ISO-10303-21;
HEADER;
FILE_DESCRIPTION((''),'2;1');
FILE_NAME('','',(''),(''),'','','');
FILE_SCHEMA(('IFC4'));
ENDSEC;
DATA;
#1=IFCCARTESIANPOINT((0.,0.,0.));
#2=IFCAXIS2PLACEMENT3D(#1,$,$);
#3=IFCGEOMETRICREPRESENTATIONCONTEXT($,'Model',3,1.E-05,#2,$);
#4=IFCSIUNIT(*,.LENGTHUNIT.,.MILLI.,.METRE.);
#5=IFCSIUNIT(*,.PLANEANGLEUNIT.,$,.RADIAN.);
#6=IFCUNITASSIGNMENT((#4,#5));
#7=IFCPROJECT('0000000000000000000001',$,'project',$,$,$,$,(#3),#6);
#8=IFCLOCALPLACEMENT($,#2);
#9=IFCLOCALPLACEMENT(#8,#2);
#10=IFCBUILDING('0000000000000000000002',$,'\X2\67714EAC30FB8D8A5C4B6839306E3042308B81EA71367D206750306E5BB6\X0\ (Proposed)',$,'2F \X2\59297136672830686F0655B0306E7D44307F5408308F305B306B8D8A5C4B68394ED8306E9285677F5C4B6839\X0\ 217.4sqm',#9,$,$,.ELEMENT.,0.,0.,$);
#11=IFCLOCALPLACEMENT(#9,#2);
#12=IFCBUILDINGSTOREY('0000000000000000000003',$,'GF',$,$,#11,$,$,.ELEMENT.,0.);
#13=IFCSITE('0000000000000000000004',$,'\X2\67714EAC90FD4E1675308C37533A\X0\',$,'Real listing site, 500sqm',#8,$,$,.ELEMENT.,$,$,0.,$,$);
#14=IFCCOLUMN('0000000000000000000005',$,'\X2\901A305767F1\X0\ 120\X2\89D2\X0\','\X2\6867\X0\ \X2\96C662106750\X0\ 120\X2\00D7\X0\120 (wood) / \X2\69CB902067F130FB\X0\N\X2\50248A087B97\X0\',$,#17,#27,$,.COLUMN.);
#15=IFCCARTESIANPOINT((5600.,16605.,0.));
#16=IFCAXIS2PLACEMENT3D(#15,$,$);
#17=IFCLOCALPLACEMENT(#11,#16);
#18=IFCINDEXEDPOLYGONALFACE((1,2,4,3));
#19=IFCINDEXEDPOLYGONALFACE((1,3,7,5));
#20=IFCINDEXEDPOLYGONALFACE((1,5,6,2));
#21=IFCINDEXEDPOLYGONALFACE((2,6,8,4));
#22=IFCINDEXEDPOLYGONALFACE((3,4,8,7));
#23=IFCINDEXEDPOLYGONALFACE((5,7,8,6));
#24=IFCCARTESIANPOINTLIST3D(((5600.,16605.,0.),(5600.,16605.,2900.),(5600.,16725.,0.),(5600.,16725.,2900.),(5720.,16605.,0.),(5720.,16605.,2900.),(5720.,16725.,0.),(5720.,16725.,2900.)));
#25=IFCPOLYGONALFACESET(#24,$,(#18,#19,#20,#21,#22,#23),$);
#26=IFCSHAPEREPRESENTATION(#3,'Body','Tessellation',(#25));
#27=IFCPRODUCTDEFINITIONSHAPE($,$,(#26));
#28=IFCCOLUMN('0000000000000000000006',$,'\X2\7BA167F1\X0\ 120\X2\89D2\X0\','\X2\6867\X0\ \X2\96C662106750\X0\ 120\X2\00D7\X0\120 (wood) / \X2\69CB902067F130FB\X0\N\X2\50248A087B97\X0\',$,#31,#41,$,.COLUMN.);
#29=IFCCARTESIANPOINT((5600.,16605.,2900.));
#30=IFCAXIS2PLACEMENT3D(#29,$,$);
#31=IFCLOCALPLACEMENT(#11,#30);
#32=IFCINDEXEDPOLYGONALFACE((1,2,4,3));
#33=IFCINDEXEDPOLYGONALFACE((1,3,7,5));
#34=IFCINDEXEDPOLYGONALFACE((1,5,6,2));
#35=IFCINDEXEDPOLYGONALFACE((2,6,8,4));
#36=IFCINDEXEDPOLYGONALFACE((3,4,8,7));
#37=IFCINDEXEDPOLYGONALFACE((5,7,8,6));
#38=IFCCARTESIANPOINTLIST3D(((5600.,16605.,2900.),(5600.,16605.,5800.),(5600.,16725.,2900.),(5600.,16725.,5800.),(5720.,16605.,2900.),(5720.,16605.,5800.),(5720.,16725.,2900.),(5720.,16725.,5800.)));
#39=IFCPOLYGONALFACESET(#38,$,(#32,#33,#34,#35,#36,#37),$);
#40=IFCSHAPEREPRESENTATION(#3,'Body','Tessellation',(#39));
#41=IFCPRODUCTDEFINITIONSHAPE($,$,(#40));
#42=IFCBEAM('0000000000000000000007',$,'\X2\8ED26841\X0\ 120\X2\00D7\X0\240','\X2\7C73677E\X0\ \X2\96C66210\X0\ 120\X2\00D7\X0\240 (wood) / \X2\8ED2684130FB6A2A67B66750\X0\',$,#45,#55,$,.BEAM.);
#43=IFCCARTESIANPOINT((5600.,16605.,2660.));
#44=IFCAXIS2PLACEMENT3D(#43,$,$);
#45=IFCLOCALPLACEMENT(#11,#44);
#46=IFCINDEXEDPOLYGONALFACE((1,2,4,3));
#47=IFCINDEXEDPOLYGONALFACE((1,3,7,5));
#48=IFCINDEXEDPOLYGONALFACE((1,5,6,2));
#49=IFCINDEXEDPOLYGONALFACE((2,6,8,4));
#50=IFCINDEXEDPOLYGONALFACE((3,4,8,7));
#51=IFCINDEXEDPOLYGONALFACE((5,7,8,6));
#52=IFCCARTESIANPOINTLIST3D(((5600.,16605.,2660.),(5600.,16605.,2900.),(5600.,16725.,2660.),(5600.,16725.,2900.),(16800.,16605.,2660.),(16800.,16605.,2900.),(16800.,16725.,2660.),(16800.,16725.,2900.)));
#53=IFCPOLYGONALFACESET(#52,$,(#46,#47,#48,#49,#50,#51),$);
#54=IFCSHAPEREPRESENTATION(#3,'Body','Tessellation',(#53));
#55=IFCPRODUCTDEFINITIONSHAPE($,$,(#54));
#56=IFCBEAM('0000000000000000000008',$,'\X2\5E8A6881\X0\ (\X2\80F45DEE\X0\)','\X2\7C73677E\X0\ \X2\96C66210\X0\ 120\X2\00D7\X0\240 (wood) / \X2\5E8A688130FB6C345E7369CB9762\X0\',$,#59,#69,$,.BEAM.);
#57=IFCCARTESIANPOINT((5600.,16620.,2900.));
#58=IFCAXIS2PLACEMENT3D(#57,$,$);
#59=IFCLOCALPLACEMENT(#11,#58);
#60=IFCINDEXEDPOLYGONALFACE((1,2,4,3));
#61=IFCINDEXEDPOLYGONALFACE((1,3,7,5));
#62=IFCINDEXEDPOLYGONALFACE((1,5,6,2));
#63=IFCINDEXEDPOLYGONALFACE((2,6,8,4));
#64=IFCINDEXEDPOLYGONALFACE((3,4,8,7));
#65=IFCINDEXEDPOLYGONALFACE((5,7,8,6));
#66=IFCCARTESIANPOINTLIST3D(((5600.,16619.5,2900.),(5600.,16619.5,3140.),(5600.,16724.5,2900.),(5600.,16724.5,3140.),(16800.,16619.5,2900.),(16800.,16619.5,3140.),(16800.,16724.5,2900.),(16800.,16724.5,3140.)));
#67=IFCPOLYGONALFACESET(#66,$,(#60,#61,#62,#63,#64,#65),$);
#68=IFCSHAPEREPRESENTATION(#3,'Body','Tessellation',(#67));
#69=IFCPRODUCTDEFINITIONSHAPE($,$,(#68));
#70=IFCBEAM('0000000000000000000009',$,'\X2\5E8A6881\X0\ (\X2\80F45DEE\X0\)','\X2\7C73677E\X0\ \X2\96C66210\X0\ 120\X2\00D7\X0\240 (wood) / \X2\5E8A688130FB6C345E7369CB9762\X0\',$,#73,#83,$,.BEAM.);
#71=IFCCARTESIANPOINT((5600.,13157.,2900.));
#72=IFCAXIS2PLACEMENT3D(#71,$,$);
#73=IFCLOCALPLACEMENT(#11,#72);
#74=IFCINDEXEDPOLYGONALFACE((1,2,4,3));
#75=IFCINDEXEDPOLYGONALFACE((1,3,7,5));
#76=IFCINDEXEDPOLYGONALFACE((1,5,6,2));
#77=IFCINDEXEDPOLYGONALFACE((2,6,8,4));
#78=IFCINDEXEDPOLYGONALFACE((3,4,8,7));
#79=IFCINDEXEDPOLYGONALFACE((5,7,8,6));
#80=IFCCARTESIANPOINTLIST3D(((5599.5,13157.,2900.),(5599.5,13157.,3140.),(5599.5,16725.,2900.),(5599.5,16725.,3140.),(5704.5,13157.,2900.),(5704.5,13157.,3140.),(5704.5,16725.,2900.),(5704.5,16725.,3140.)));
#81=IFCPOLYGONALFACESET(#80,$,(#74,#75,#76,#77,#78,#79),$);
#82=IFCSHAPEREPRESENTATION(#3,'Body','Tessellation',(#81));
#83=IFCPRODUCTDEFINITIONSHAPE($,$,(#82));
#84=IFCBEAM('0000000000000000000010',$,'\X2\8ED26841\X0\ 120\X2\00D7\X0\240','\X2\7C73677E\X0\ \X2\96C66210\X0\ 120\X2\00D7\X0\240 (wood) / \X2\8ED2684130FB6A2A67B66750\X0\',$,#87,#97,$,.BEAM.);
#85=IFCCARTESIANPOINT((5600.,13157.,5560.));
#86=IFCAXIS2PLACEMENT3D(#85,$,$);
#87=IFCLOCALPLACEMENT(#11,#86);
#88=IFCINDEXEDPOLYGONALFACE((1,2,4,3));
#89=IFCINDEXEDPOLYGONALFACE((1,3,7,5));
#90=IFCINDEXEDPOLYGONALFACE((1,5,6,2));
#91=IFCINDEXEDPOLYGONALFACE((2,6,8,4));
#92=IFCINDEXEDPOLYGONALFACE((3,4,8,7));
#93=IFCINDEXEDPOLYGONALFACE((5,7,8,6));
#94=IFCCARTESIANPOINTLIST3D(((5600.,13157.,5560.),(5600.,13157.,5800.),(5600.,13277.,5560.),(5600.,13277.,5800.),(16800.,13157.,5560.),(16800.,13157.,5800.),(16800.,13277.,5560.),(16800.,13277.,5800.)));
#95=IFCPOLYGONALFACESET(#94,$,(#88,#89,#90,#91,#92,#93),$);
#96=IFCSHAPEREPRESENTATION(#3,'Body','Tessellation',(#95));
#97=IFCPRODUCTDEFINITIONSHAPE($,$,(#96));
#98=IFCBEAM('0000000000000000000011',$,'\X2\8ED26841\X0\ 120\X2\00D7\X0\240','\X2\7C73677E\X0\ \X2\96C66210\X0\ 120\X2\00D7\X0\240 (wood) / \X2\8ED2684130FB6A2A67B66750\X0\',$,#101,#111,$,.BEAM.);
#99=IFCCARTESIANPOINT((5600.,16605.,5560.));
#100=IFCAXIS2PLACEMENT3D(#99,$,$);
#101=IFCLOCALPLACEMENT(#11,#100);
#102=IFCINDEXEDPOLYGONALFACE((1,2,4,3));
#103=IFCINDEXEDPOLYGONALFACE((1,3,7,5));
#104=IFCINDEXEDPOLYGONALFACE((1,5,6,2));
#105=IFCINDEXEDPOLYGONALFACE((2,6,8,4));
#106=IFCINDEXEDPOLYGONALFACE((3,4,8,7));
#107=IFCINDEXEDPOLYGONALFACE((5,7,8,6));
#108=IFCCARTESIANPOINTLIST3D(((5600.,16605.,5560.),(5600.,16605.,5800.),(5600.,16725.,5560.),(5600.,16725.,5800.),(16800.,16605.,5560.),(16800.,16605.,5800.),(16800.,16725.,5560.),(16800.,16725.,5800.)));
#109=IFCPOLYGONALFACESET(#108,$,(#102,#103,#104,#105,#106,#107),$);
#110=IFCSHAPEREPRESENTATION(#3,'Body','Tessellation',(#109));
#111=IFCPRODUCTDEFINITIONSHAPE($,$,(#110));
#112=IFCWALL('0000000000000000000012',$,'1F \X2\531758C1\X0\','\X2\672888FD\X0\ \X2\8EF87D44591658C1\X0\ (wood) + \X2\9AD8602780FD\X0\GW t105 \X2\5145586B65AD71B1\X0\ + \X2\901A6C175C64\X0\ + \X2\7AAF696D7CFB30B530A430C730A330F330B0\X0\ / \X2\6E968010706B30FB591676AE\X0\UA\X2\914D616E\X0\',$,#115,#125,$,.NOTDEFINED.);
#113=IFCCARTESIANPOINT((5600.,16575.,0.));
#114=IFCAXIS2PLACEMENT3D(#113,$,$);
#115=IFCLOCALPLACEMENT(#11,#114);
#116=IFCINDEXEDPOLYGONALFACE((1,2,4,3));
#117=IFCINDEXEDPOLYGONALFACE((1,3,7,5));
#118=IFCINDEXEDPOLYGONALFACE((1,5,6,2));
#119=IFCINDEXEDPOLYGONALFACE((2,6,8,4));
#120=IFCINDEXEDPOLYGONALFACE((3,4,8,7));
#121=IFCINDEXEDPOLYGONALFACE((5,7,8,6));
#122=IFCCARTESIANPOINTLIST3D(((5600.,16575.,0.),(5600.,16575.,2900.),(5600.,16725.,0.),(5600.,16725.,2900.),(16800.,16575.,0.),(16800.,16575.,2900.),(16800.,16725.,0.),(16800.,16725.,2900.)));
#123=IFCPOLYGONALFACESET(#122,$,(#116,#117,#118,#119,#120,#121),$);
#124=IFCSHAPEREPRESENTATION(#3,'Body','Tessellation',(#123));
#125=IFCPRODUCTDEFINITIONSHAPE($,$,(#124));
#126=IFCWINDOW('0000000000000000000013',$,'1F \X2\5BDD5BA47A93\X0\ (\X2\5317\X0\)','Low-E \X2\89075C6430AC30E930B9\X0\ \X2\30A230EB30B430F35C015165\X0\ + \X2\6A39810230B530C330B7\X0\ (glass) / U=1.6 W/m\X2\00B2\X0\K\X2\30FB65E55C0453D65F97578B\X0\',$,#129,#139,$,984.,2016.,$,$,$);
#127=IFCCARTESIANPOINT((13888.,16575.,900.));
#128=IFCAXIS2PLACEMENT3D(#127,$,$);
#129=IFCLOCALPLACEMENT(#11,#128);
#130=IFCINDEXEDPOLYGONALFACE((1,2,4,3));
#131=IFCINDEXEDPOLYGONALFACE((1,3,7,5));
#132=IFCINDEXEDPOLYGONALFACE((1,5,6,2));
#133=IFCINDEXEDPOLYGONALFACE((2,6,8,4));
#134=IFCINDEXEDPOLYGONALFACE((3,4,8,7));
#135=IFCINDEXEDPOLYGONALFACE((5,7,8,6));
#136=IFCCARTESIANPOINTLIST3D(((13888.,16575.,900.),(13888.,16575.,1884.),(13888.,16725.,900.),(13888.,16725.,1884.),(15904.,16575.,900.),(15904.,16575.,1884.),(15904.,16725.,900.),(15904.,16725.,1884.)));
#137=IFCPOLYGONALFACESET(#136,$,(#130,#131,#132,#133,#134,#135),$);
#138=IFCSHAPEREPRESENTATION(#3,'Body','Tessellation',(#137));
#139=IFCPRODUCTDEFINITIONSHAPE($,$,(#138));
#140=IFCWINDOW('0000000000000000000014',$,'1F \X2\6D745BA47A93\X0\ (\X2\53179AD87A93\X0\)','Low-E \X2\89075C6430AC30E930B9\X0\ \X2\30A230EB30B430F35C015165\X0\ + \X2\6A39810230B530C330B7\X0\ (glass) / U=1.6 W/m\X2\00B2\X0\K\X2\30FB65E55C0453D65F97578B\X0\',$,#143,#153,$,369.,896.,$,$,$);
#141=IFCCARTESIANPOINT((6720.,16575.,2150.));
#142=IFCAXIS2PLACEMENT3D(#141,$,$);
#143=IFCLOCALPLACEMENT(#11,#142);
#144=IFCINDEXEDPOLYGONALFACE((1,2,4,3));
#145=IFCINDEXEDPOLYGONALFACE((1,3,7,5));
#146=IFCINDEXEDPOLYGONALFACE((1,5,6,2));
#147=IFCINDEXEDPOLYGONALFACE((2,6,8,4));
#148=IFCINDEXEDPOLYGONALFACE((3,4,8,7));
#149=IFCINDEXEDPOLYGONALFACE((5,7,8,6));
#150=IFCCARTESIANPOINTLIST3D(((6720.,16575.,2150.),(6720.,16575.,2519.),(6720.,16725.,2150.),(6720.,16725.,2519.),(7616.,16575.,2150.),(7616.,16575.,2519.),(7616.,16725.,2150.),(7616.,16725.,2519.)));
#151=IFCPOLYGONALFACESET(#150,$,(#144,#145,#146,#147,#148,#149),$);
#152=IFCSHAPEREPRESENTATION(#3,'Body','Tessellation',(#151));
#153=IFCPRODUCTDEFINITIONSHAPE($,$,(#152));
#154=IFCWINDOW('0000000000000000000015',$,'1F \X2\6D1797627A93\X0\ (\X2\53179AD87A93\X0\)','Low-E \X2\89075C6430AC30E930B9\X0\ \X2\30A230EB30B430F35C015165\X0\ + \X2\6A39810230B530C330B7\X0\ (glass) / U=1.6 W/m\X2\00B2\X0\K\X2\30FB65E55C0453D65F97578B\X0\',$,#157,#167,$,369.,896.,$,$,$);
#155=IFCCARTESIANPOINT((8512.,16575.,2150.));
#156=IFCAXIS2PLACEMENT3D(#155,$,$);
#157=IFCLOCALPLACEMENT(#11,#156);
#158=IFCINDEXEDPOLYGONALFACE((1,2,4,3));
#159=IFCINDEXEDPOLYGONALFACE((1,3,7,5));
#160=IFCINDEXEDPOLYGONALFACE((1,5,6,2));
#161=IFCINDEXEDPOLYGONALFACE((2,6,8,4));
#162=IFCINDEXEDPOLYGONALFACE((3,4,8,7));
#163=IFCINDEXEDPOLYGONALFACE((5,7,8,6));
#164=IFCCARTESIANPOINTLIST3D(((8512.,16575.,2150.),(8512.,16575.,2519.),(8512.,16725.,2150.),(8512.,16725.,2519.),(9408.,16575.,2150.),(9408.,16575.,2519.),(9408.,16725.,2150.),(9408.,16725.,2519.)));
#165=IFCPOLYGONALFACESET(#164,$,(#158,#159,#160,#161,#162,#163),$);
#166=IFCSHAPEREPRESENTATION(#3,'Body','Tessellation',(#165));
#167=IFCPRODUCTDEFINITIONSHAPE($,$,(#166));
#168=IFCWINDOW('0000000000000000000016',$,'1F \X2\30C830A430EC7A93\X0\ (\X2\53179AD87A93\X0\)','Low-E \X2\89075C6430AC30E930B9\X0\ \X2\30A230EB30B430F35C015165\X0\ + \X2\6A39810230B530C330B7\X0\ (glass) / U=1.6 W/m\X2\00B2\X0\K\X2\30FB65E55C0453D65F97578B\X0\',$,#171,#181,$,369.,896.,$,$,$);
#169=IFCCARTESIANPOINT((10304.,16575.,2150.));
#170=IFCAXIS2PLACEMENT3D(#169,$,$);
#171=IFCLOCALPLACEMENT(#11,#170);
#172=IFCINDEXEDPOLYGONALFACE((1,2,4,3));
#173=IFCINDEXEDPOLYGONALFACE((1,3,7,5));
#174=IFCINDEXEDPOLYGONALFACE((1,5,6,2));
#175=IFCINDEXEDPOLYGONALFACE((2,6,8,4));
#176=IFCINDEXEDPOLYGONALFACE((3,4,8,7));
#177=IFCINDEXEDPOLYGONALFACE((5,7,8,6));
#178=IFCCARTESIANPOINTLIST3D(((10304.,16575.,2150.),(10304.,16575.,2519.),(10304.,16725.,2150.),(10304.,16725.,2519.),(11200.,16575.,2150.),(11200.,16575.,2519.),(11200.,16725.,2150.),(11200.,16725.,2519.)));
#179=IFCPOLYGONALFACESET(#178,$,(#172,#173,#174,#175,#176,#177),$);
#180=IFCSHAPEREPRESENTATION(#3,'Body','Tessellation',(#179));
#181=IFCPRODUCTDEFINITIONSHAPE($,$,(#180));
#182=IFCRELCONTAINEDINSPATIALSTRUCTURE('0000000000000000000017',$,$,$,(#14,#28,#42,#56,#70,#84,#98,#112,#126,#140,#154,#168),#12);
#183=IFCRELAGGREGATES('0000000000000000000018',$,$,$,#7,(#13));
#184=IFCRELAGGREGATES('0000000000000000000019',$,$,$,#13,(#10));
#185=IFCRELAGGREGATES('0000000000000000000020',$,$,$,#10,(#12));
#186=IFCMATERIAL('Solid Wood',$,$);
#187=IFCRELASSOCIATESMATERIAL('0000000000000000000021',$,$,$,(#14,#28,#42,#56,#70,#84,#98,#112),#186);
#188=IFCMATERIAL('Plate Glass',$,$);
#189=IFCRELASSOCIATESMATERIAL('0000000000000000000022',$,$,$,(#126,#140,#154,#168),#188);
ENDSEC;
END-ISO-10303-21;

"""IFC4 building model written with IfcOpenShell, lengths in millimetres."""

from ifc_helpers import new_model, si_unit, frame, frame_2d, origin, place, context, project, spatial, rectangle, extrude, material, element, fill, save


model = new_model("IFC4")

# Units and contexts
model_context = context("Model", 3, precision=1e-05, world=origin())
ifc_project = project(units=[si_unit("LENGTHUNIT", "METRE", prefix="MILLI"), si_unit("PLANEANGLEUNIT", "RADIAN")], contexts=[model_context])

# Site, building, storey
site_placement = place(None, origin())
site = spatial("IfcSite", under=ifc_project, at=site_placement, Name="東京都世田谷区", ObjectType="Real listing site, 500sqm", CompositionType="ELEMENT", RefElevation=0.0)
building_placement = place(site_placement, origin())
building = spatial("IfcBuilding", under=site, at=building_placement, Name="東京・越屋根のある自然素材の家 (Proposed)", ObjectType="2F 天然木と漆喰の組み合わせに越屋根付の銅板屋根 217.4sqm", CompositionType="ELEMENT", ElevationOfRefHeight=0.0, ElevationOfTerrain=0.0)
storey_placement = place(building_placement, origin())
storey = spatial("IfcBuildingStorey", under=building, at=storey_placement, Name="GF", CompositionType="ELEMENT", Elevation=0.0)

# Columns
ifc_material_1 = material(Name="Solid Wood")
column_1_placement = place(storey_placement, frame((5600.0, 16605.0, 0.0)))
element("IfcColumn", 1, at=column_1_placement, inside=storey, material=ifc_material_1, Name="通し柱 120角", Description="桧 集成材 120×120 (wood) / 構造柱・N値計算", PredefinedType="COLUMN", context=model_context, shape_type="SweptSolid", body=[
    extrude(rectangle(XDim=120.0, YDim=120.0, at=frame_2d((60.0, 60.0))), frame((5600.0, 16605.0, 0.0)), (0.0, 0.0, 1.0), 2900.0),
])
column_2_placement = place(storey_placement, frame((5600.0, 16605.0, 2900.0)))
element("IfcColumn", 2, at=column_2_placement, inside=storey, material=ifc_material_1, Name="管柱 120角", Description="桧 集成材 120×120 (wood) / 構造柱・N値計算", PredefinedType="COLUMN", context=model_context, shape_type="SweptSolid", body=[
    extrude(rectangle(XDim=120.0, YDim=120.0, at=frame_2d((60.0, 60.0))), frame((5600.0, 16605.0, 2900.0)), (0.0, 0.0, 1.0), 2900.0),
])

# Beams
beam_1_placement = place(storey_placement, frame((5600.0, 16605.0, 2660.0)))
element("IfcBeam", 3, at=beam_1_placement, inside=storey, material=ifc_material_1, Name="軒桁 120×240", Description="米松 集成 120×240 (wood) / 軒桁・横架材", PredefinedType="BEAM", context=model_context, shape_type="SweptSolid", body=[
    extrude(rectangle(XDim=11200.0, YDim=120.0, at=frame_2d((5600.0, 60.0))), frame((5600.0, 16605.0, 2660.0)), (0.0, 0.0, 1.0), 240.0),
])
beam_2_placement = place(storey_placement, frame((5600.0, 16620.0, 2900.0)))
element("IfcBeam", 4, at=beam_2_placement, inside=storey, material=ifc_material_1, Name="床梁 (胴差)", Description="米松 集成 120×240 (wood) / 床梁・水平構面", PredefinedType="BEAM", context=model_context, shape_type="SweptSolid", body=[
    extrude(rectangle(XDim=11200.0, YDim=105.0, at=frame_2d((5600.0, 52.0))), frame((5600.0, 16620.0, 2900.0)), (0.0, 0.0, 1.0), 240.0),
])
beam_3_placement = place(storey_placement, frame((5600.0, 13157.0, 2900.0)))
element("IfcBeam", 5, at=beam_3_placement, inside=storey, material=ifc_material_1, Name="床梁 (胴差)", Description="米松 集成 120×240 (wood) / 床梁・水平構面", PredefinedType="BEAM", context=model_context, shape_type="SweptSolid", body=[
    extrude(rectangle(XDim=105.0, YDim=3568.0, at=frame_2d((52.0, 1784.0))), frame((5600.0, 13157.0, 2900.0)), (0.0, 0.0, 1.0), 240.0),
])
beam_4_placement = place(storey_placement, frame((5600.0, 13157.0, 5560.0)))
element("IfcBeam", 6, at=beam_4_placement, inside=storey, material=ifc_material_1, Name="軒桁 120×240", Description="米松 集成 120×240 (wood) / 軒桁・横架材", PredefinedType="BEAM", context=model_context, shape_type="SweptSolid", body=[
    extrude(rectangle(XDim=11200.0, YDim=120.0, at=frame_2d((5600.0, 60.0))), frame((5600.0, 13157.0, 5560.0)), (0.0, 0.0, 1.0), 240.0),
])
beam_5_placement = place(storey_placement, frame((5600.0, 16605.0, 5560.0)))
element("IfcBeam", 7, at=beam_5_placement, inside=storey, material=ifc_material_1, Name="軒桁 120×240", Description="米松 集成 120×240 (wood) / 軒桁・横架材", PredefinedType="BEAM", context=model_context, shape_type="SweptSolid", body=[
    extrude(rectangle(XDim=11200.0, YDim=120.0, at=frame_2d((5600.0, 60.0))), frame((5600.0, 16605.0, 5560.0)), (0.0, 0.0, 1.0), 240.0),
])

# Wall, openings, windows
wall_1_placement = place(storey_placement, frame((5600.0, 16575.0, 0.0)))
wall_1 = element("IfcWall", 8, at=wall_1_placement, inside=storey, material=ifc_material_1, Name="1F 北壁", Description="木製 軸組外壁 (wood) + 高性能GW t105 充填断熱 + 通気層 + 窯業系サイディング / 準耐火・外皮UA配慮", PredefinedType="NOTDEFINED", context=model_context, shape_type="SweptSolid", body=[
    extrude(rectangle(XDim=11200.0, YDim=150.0, at=frame_2d((5600.0, 75.0))), frame((5600.0, 16575.0, 0.0)), (0.0, 0.0, 1.0), 2900.0),
])
opening_1_placement = place(storey_placement, frame((13888.0, 16575.0, 900.0)))
opening_1 = element("IfcOpeningElement", 9, at=opening_1_placement, cuts=wall_1, PredefinedType="NOTDEFINED", context=model_context, shape_type="SweptSolid", body=[
    extrude(rectangle(XDim=2016.0, YDim=150.0, at=frame_2d((1008.0, 75.0))), frame((13888.0, 16575.0, 900.0)), (0.0, 0.0, 1.0), 984.0),
])
opening_2_placement = place(storey_placement, frame((6720.0, 16575.0, 2150.0)))
opening_2 = element("IfcOpeningElement", 10, at=opening_2_placement, cuts=wall_1, PredefinedType="NOTDEFINED", context=model_context, shape_type="SweptSolid", body=[
    extrude(rectangle(XDim=896.0, YDim=150.0, at=frame_2d((448.0, 75.0))), frame((6720.0, 16575.0, 2150.0)), (0.0, 0.0, 1.0), 369.0),
])
opening_3_placement = place(storey_placement, frame((8512.0, 16575.0, 2150.0)))
opening_3 = element("IfcOpeningElement", 11, at=opening_3_placement, cuts=wall_1, PredefinedType="NOTDEFINED", context=model_context, shape_type="SweptSolid", body=[
    extrude(rectangle(XDim=896.0, YDim=150.0, at=frame_2d((448.0, 75.0))), frame((8512.0, 16575.0, 2150.0)), (0.0, 0.0, 1.0), 369.0),
])
opening_4_placement = place(storey_placement, frame((10304.0, 16575.0, 2150.0)))
opening_4 = element("IfcOpeningElement", 12, at=opening_4_placement, cuts=wall_1, PredefinedType="NOTDEFINED", context=model_context, shape_type="SweptSolid", body=[
    extrude(rectangle(XDim=896.0, YDim=150.0, at=frame_2d((448.0, 75.0))), frame((10304.0, 16575.0, 2150.0)), (0.0, 0.0, 1.0), 369.0),
])
ifc_material_2 = material(Name="Plate Glass")
window_1_placement = place(storey_placement, frame((13888.0, 16575.0, 900.0)))
window_1 = element("IfcWindow", 13, at=window_1_placement, inside=storey, material=ifc_material_2, Name="1F 寝室窓 (北)", Description="Low-E 複層ガラス アルゴン封入 + 樹脂サッシ (glass) / U=1.6 W/m²K・日射取得型", OverallHeight=984.0, OverallWidth=2016.0, context=model_context, shape_type="SweptSolid", body=[
    extrude(rectangle(XDim=2016.0, YDim=150.0, at=frame_2d((1008.0, 75.0))), frame((13888.0, 16575.0, 900.0)), (0.0, 0.0, 1.0), 984.0),
])
fill(opening_1, window_1)
window_2_placement = place(storey_placement, frame((6720.0, 16575.0, 2150.0)))
window_2 = element("IfcWindow", 14, at=window_2_placement, inside=storey, material=ifc_material_2, Name="1F 浴室窓 (北高窓)", Description="Low-E 複層ガラス アルゴン封入 + 樹脂サッシ (glass) / U=1.6 W/m²K・日射取得型", OverallHeight=369.0, OverallWidth=896.0, context=model_context, shape_type="SweptSolid", body=[
    extrude(rectangle(XDim=896.0, YDim=150.0, at=frame_2d((448.0, 75.0))), frame((6720.0, 16575.0, 2150.0)), (0.0, 0.0, 1.0), 369.0),
])
fill(opening_2, window_2)
window_3_placement = place(storey_placement, frame((8512.0, 16575.0, 2150.0)))
window_3 = element("IfcWindow", 15, at=window_3_placement, inside=storey, material=ifc_material_2, Name="1F 洗面窓 (北高窓)", Description="Low-E 複層ガラス アルゴン封入 + 樹脂サッシ (glass) / U=1.6 W/m²K・日射取得型", OverallHeight=369.0, OverallWidth=896.0, context=model_context, shape_type="SweptSolid", body=[
    extrude(rectangle(XDim=896.0, YDim=150.0, at=frame_2d((448.0, 75.0))), frame((8512.0, 16575.0, 2150.0)), (0.0, 0.0, 1.0), 369.0),
])
fill(opening_3, window_3)
window_4_placement = place(storey_placement, frame((10304.0, 16575.0, 2150.0)))
window_4 = element("IfcWindow", 16, at=window_4_placement, inside=storey, material=ifc_material_2, Name="1F トイレ窓 (北高窓)", Description="Low-E 複層ガラス アルゴン封入 + 樹脂サッシ (glass) / U=1.6 W/m²K・日射取得型", OverallHeight=369.0, OverallWidth=896.0, context=model_context, shape_type="SweptSolid", body=[
    extrude(rectangle(XDim=896.0, YDim=150.0, at=frame_2d((448.0, 75.0))), frame((10304.0, 16575.0, 2150.0)), (0.0, 0.0, 1.0), 369.0),
])
fill(opening_4, window_4)

save(model, "model.ifc")
